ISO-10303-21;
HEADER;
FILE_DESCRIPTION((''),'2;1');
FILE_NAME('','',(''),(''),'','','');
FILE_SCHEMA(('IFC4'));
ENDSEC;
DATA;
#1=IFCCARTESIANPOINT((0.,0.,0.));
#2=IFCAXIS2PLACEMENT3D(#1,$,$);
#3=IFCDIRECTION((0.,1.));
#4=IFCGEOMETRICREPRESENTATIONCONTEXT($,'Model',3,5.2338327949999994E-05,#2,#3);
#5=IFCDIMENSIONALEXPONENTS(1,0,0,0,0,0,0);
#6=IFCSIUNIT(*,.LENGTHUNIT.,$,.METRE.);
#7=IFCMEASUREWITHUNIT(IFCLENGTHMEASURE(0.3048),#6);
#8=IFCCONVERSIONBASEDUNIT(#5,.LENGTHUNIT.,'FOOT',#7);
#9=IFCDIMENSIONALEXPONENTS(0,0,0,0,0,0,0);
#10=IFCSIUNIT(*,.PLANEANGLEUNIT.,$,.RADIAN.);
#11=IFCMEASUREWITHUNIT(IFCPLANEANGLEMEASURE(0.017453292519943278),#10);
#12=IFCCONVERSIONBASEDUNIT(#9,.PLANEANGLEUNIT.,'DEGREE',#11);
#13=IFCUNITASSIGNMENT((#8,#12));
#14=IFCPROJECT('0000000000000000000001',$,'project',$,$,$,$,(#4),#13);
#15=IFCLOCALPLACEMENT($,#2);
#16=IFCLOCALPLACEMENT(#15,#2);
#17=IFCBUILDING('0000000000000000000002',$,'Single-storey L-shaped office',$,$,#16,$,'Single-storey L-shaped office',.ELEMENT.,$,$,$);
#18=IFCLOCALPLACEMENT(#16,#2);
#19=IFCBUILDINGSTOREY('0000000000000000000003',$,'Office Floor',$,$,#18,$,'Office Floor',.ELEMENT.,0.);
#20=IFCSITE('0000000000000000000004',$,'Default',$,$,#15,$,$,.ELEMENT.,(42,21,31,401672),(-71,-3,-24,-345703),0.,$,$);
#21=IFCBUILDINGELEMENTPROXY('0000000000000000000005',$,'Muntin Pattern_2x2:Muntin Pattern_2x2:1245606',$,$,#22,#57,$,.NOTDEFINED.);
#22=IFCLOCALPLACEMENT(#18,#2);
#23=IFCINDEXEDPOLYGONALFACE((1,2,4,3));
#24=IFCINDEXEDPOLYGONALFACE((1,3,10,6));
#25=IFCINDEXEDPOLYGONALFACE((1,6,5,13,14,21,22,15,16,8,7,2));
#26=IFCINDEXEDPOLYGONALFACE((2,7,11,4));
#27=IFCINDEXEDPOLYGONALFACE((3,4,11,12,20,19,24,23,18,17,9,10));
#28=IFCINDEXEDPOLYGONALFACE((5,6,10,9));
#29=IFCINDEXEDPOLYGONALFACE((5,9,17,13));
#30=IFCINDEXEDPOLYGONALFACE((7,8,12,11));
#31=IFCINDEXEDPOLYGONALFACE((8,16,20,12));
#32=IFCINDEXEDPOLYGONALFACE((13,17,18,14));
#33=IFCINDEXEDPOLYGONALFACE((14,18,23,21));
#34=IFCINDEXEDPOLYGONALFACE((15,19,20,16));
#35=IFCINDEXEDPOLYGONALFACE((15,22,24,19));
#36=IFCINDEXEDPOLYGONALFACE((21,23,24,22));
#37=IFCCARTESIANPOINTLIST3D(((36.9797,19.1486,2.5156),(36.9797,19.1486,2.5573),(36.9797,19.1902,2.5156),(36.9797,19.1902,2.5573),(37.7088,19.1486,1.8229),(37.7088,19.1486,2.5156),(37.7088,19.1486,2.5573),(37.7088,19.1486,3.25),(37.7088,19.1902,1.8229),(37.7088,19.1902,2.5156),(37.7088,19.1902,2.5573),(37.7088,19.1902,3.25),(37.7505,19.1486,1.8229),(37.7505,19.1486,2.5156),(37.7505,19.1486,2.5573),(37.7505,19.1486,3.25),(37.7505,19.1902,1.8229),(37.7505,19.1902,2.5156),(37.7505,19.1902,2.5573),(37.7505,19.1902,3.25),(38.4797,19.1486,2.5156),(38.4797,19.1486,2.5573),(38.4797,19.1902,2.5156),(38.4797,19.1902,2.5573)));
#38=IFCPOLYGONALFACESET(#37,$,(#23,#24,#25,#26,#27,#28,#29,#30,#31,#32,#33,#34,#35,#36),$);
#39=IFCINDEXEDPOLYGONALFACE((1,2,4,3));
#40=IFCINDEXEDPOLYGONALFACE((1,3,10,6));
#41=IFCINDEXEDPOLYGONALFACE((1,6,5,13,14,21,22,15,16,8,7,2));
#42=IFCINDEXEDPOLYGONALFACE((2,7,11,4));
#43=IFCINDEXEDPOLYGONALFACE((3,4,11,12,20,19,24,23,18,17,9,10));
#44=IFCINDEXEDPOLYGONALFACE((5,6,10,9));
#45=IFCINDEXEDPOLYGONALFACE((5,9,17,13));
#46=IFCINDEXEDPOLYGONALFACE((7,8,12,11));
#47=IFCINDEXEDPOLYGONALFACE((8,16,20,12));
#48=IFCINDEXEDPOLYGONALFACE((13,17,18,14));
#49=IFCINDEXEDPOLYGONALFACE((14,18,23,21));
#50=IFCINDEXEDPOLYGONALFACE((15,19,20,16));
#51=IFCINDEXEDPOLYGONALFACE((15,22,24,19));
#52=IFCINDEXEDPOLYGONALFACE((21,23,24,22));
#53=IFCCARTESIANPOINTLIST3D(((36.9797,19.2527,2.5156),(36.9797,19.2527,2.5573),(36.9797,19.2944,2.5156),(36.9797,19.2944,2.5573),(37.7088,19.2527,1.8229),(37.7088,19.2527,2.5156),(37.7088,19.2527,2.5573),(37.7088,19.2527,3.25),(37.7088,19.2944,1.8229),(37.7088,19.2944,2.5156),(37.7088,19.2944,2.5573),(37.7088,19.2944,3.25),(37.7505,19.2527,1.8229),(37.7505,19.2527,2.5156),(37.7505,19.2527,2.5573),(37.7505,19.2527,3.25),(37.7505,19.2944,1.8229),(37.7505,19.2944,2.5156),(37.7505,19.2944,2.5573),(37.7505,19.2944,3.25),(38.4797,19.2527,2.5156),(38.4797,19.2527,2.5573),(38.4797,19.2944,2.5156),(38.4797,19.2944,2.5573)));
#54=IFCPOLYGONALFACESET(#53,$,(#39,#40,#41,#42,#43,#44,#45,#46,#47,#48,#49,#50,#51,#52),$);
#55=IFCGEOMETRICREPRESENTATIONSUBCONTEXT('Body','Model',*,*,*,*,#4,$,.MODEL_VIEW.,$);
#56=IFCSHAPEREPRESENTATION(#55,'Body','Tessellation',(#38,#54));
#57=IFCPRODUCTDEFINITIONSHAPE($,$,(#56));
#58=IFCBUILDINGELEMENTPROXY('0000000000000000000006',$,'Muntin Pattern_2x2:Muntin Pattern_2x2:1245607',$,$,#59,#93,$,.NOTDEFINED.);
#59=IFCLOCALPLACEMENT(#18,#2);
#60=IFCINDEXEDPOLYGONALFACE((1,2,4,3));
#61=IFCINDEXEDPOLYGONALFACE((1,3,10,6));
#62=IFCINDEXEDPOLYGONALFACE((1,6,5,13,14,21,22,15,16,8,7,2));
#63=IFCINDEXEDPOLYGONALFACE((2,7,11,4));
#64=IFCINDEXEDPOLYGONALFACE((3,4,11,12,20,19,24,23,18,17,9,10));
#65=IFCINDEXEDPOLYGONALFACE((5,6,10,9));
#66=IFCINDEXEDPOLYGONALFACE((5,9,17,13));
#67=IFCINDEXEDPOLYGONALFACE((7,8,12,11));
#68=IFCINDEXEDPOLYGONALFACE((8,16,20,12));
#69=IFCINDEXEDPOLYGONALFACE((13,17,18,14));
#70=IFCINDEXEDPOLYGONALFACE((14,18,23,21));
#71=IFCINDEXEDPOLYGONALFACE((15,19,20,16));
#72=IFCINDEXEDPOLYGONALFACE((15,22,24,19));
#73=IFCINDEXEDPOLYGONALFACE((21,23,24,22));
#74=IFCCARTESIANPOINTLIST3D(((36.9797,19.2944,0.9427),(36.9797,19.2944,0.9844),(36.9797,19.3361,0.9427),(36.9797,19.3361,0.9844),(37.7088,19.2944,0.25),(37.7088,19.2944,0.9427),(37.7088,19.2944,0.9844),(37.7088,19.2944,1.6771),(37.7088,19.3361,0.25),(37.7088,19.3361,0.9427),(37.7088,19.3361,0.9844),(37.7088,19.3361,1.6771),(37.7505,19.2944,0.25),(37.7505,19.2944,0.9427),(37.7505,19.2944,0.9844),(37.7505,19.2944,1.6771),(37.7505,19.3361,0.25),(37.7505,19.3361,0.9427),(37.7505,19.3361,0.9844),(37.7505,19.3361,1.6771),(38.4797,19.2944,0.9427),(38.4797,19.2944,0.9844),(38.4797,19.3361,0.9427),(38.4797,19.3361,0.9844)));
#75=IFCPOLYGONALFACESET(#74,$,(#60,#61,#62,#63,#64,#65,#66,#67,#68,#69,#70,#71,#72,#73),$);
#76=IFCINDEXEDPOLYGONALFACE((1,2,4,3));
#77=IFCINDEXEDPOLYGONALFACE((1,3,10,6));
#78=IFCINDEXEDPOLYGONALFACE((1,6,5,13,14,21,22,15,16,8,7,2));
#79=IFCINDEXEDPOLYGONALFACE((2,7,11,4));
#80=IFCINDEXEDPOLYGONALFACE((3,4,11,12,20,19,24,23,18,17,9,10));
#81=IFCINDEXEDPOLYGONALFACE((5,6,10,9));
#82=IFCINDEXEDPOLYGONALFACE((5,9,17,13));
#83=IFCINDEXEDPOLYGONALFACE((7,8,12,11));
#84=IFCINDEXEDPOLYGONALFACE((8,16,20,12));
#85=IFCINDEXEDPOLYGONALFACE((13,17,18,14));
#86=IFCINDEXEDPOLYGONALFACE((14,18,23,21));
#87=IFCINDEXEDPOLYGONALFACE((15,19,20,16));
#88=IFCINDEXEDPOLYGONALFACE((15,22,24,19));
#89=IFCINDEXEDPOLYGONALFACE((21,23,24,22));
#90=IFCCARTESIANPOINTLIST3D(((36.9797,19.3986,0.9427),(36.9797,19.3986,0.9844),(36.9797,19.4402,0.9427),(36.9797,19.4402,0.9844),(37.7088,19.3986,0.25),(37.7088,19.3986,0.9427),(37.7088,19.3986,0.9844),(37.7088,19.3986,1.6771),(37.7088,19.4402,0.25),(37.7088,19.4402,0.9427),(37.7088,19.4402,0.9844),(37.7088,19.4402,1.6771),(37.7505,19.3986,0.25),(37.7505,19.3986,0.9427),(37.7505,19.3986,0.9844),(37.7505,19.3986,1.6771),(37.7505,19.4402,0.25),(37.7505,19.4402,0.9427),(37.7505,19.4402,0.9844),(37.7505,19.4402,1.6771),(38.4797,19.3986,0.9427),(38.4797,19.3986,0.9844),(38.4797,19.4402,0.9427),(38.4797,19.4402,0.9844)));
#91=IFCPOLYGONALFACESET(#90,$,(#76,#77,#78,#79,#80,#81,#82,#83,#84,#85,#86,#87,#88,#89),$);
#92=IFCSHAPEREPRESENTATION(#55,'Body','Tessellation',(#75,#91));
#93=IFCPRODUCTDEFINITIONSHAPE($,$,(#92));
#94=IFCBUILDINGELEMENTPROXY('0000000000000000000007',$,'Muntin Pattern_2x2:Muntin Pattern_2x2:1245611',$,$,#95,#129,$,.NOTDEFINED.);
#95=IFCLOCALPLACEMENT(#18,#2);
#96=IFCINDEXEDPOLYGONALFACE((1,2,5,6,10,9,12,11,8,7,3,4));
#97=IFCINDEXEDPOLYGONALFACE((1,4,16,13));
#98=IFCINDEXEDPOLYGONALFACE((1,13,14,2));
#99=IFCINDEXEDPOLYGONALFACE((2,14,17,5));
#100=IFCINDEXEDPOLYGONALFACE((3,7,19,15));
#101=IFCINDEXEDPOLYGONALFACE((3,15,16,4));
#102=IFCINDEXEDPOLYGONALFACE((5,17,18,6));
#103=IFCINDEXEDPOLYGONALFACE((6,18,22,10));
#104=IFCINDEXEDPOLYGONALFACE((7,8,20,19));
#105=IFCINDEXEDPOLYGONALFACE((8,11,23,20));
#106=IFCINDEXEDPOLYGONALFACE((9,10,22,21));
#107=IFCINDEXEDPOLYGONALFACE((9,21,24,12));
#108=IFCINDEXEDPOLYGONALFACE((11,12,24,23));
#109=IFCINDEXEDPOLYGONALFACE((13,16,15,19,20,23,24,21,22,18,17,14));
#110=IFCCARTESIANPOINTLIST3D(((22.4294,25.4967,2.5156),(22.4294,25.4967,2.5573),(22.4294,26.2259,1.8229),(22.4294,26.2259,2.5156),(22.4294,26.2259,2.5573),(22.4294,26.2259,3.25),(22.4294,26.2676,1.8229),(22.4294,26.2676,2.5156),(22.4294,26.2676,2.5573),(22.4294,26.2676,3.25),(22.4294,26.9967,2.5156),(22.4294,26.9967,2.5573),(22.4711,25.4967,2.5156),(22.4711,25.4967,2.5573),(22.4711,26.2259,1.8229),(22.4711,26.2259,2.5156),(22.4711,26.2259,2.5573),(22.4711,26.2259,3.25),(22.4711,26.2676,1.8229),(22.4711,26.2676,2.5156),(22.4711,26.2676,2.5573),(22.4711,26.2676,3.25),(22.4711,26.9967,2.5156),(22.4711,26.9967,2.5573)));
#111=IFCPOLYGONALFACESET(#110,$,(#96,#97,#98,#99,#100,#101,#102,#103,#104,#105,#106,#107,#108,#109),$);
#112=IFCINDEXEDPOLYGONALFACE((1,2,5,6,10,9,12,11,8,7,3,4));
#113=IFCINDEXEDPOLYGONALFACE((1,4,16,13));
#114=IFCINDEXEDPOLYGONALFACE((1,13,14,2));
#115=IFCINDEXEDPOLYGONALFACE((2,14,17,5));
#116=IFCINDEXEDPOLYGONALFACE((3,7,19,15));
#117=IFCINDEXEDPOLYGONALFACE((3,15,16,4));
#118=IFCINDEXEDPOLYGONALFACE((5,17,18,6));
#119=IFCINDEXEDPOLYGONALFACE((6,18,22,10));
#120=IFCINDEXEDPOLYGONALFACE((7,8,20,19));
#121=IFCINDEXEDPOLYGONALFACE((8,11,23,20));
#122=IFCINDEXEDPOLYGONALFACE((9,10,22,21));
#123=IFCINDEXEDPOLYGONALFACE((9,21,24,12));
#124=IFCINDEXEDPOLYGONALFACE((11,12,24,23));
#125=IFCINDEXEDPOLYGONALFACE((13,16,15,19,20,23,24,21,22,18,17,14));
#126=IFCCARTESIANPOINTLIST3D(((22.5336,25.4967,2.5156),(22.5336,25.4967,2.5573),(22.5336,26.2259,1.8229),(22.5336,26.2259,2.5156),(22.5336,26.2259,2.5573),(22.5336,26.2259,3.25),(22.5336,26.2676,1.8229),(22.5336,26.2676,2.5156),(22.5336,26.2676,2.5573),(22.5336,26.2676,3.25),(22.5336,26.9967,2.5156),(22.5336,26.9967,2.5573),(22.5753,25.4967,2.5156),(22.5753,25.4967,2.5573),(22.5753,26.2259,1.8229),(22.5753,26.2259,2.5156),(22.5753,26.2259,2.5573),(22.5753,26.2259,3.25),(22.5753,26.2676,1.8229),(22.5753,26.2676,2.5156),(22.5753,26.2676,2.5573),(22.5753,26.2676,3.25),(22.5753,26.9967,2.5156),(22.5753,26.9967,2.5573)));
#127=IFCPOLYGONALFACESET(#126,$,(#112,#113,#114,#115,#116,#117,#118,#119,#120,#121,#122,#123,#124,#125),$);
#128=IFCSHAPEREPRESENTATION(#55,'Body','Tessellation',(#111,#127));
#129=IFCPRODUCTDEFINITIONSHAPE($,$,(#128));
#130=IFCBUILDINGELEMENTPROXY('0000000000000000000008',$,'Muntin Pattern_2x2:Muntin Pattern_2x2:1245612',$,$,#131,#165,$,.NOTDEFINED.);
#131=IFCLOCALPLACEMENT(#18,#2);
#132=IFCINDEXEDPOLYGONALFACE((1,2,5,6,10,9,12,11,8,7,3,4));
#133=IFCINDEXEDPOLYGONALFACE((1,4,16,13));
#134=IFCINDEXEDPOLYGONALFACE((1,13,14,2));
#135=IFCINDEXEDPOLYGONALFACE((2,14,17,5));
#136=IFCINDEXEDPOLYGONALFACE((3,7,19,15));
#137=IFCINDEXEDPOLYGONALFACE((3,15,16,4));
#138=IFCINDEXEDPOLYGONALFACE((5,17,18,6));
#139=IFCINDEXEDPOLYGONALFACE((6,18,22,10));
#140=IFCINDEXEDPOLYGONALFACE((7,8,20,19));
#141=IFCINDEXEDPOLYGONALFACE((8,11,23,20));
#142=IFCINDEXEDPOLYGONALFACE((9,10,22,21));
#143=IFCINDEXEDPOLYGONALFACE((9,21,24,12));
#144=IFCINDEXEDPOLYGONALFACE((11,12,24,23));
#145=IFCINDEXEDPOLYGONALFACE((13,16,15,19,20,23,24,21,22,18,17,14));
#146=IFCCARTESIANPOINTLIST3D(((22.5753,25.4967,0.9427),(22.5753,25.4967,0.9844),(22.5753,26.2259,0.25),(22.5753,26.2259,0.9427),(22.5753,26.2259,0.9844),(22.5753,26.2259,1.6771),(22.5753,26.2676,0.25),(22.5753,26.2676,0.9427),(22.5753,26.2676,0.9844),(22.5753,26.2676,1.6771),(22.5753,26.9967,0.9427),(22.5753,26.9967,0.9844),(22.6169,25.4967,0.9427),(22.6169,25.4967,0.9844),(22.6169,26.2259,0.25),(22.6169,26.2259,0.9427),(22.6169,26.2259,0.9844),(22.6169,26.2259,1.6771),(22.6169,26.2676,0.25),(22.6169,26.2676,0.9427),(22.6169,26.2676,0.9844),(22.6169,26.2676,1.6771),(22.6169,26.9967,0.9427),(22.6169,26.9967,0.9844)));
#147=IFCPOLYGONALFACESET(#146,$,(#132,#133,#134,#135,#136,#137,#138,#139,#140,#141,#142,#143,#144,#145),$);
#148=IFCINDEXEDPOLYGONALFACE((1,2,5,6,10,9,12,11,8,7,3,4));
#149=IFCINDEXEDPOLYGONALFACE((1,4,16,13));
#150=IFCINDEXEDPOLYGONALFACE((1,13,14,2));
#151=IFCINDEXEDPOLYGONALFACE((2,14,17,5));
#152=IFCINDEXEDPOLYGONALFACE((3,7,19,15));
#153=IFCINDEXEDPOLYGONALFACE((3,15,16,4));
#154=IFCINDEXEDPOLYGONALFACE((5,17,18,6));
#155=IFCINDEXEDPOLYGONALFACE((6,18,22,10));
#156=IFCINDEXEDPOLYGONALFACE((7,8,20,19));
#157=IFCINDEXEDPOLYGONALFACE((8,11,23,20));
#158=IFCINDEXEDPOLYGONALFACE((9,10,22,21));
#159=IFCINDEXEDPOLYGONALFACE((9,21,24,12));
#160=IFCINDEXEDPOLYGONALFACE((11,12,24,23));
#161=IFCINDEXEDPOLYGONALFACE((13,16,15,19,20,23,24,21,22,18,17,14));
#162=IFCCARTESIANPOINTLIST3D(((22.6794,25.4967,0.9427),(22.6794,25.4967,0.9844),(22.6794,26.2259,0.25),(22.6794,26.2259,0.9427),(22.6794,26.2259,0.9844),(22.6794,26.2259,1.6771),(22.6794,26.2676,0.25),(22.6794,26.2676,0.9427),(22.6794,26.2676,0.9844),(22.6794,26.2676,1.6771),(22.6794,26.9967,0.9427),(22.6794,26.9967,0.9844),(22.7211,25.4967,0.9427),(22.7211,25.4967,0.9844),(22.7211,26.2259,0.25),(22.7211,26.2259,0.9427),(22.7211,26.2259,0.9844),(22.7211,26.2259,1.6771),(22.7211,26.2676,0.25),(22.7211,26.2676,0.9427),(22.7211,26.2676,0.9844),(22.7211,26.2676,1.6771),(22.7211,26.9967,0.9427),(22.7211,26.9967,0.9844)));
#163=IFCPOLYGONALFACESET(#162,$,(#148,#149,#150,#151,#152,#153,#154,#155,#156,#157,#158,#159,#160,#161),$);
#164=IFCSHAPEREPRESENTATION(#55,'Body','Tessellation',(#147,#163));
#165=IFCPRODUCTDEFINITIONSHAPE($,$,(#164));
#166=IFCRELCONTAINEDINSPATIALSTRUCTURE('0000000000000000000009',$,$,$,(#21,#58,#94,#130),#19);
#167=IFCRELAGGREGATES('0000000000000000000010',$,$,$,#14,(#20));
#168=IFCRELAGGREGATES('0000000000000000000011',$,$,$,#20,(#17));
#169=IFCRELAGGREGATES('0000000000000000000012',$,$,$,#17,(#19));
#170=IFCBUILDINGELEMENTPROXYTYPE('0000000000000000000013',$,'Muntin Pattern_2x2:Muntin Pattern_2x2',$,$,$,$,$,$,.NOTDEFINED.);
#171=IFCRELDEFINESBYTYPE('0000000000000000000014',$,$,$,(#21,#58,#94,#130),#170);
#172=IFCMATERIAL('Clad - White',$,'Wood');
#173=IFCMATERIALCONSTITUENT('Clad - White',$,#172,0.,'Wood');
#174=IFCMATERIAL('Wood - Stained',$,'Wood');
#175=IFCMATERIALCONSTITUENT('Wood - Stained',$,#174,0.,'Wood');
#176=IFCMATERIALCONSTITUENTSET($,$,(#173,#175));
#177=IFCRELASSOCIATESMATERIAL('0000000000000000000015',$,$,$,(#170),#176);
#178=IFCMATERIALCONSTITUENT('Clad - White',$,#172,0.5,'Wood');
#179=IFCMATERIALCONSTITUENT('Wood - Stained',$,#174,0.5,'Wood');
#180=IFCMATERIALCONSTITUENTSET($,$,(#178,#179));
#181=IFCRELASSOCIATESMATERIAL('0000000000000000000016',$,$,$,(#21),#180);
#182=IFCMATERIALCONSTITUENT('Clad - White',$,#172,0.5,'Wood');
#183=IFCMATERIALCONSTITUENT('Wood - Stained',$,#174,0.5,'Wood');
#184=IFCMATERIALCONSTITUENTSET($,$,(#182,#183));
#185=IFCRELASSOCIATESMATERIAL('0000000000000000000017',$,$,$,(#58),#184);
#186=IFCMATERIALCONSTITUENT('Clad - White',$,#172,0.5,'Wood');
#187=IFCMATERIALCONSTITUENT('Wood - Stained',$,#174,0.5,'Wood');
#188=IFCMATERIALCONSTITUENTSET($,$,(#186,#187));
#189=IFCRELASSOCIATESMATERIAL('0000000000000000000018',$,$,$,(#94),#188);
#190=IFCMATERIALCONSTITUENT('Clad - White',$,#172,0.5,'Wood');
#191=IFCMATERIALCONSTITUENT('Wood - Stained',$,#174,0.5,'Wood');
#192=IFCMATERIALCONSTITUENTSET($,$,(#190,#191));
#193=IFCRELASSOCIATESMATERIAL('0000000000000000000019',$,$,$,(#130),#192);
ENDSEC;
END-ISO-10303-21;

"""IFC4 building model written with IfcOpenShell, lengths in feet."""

from ifc_helpers import new_model, entity, si_unit, converted_unit, direction, frame, origin, place, context, subcontext, project, spatial, indexed_curve, outline, extrude, source, transform, mapped, material, constituent, constituent_set, type_object, type_shapes, element, save


model = new_model("IFC4")

# Units and contexts
model_context = context("Model", 3, precision=5.2338327949999994e-05, world=origin(), true_north=direction((0.0, 1.0)))
body_context = subcontext(model_context, "Body", "Model", "MODEL_VIEW")
ifc_project = project(units=[converted_unit("LENGTHUNIT", "FOOT", entity("IfcLengthMeasure", 0.3048), si_unit("LENGTHUNIT", "METRE"), dimensions=[1, 0, 0, 0, 0, 0, 0]), converted_unit("PLANEANGLEUNIT", "DEGREE", entity("IfcPlaneAngleMeasure", 0.017453292519943278), si_unit("PLANEANGLEUNIT", "RADIAN"), dimensions=[0, 0, 0, 0, 0, 0, 0])], contexts=[model_context])

# Site, building, storey
site_placement = place(None, origin())
site = spatial("IfcSite", under=ifc_project, at=site_placement, Name="Default", CompositionType="ELEMENT", RefLatitude=(42, 21, 31, 401672), RefLongitude=(-71, -3, -24, -345703), RefElevation=0.0)
building_placement = place(site_placement, origin())
building = spatial("IfcBuilding", under=site, at=building_placement, Name="Single-storey L-shaped office", LongName="Single-storey L-shaped office", CompositionType="ELEMENT")
storey_placement = place(building_placement, origin())
storey = spatial("IfcBuildingStorey", under=building, at=storey_placement, Name="Office Floor", LongName="Office Floor", CompositionType="ELEMENT", Elevation=0.0)

# Shared definitions
ifc_material_1 = material(Name="Wood - Stained", Category="Wood")

# Building element proxies
ifc_material_2 = material(Name="Clad - White", Category="Wood")
ifc_constituent_1 = constituent(ifc_material_2, Name="Clad - White", Category="Wood", fraction=0.0)
ifc_constituent_2 = constituent(ifc_material_1, Name="Wood - Stained", Category="Wood", fraction=0.0)
ifc_constituent_set_1 = constituent_set(constituents=[ifc_constituent_1, ifc_constituent_2])
building_element_proxy_type_1 = type_object("IfcBuildingElementProxyType", Name="Muntin Pattern_2x2:Muntin Pattern_2x2", PredefinedType="NOTDEFINED", material=ifc_constituent_set_1)
shared_shape_1 = source(origin(), body_context, "Body", "SweptSolid", [
    extrude(outline(indexed_curve([(0.0208, -0.0208), (0.7135, -0.0208), (0.7135, 0.0208), (0.0208, 0.0208), (0.0208, 0.75), (-0.0208, 0.75), (-0.0208, 0.0208), (-0.7135, 0.0208), (-0.7135, -0.0208), (-0.0208, -0.0208), (-0.0208, -0.75), (0.0208, -0.75), (0.0208, -0.0208)], self_intersect=False)), frame((0.0, 0.0312, 0.7135), z_axis=(0.0, 1.0, 0.0), x_axis=(0.0, 0.0, 1.0)), (0.0, 0.0, 1.0), 0.0417),
    extrude(outline(indexed_curve([(0.0208, -0.0208), (0.7135, -0.0208), (0.7135, 0.0208), (0.0208, 0.0208), (0.0208, 0.75), (-0.0208, 0.75), (-0.0208, 0.0208), (-0.7135, 0.0208), (-0.7135, -0.0208), (-0.0208, -0.0208), (-0.0208, -0.75), (0.0208, -0.75), (0.0208, -0.0208)], self_intersect=False)), frame((0.0, -0.0729, 0.7135), z_axis=(0.0, 1.0, 0.0), x_axis=(0.0, 0.0, 1.0)), (0.0, 0.0, 1.0), 0.0417),
])
type_shapes(building_element_proxy_type_1, [shared_shape_1])
ifc_constituent_3 = constituent(ifc_material_2, Name="Clad - White", Category="Wood", fraction=0.5)
ifc_constituent_4 = constituent(ifc_material_1, Name="Wood - Stained", Category="Wood", fraction=0.5)
ifc_constituent_set_2 = constituent_set(constituents=[ifc_constituent_3, ifc_constituent_4])
proxy_1_placement = place(storey_placement, frame((37.7297, 19.2215, 1.8229), z_axis=(0.0, 0.0, 1.0), x_axis=(-1.0, 0.0, 0.0)))
element("IfcBuildingElementProxy", 1, at=proxy_1_placement, inside=storey, type_object=building_element_proxy_type_1, material=ifc_constituent_set_2, Name="Muntin Pattern_2x2:Muntin Pattern_2x2:1245606", PredefinedType="NOTDEFINED", context=body_context, shape_type="MappedRepresentation", body=[
    mapped(shared_shape_1, transform((0.0, 0.0, 0.0), scale=1.0)),
])
ifc_constituent_5 = constituent(ifc_material_2, Name="Clad - White", Category="Wood", fraction=0.5)
ifc_constituent_6 = constituent(ifc_material_1, Name="Wood - Stained", Category="Wood", fraction=0.5)
ifc_constituent_set_3 = constituent_set(constituents=[ifc_constituent_5, ifc_constituent_6])
proxy_2_placement = place(storey_placement, frame((37.7297, 19.3673, 0.25), z_axis=(0.0, 0.0, 1.0), x_axis=(-1.0, 0.0, 0.0)))
element("IfcBuildingElementProxy", 2, at=proxy_2_placement, inside=storey, type_object=building_element_proxy_type_1, material=ifc_constituent_set_3, Name="Muntin Pattern_2x2:Muntin Pattern_2x2:1245607", PredefinedType="NOTDEFINED", context=body_context, shape_type="MappedRepresentation", body=[
    mapped(shared_shape_1, transform((0.0, 0.0, 0.0), scale=1.0)),
])
ifc_constituent_7 = constituent(ifc_material_2, Name="Clad - White", Category="Wood", fraction=0.5)
ifc_constituent_8 = constituent(ifc_material_1, Name="Wood - Stained", Category="Wood", fraction=0.5)
ifc_constituent_set_4 = constituent_set(constituents=[ifc_constituent_7, ifc_constituent_8])
proxy_3_placement = place(storey_placement, frame((22.5023, 26.2467, 1.8229), z_axis=(0.0, 0.0, 1.0), x_axis=(0.0, 1.0, 0.0)))
element("IfcBuildingElementProxy", 3, at=proxy_3_placement, inside=storey, type_object=building_element_proxy_type_1, material=ifc_constituent_set_4, Name="Muntin Pattern_2x2:Muntin Pattern_2x2:1245611", PredefinedType="NOTDEFINED", context=body_context, shape_type="MappedRepresentation", body=[
    mapped(shared_shape_1, transform((0.0, 0.0, 0.0), scale=1.0)),
])
ifc_constituent_9 = constituent(ifc_material_2, Name="Clad - White", Category="Wood", fraction=0.5)
ifc_constituent_10 = constituent(ifc_material_1, Name="Wood - Stained", Category="Wood", fraction=0.5)
ifc_constituent_set_5 = constituent_set(constituents=[ifc_constituent_9, ifc_constituent_10])
proxy_4_placement = place(storey_placement, frame((22.6482, 26.2467, 0.25), z_axis=(0.0, 0.0, 1.0), x_axis=(0.0, 1.0, 0.0)))
element("IfcBuildingElementProxy", 4, at=proxy_4_placement, inside=storey, type_object=building_element_proxy_type_1, material=ifc_constituent_set_5, Name="Muntin Pattern_2x2:Muntin Pattern_2x2:1245612", PredefinedType="NOTDEFINED", context=body_context, shape_type="MappedRepresentation", body=[
    mapped(shared_shape_1, transform((0.0, 0.0, 0.0), scale=1.0)),
])

save(model, "model.ifc")
